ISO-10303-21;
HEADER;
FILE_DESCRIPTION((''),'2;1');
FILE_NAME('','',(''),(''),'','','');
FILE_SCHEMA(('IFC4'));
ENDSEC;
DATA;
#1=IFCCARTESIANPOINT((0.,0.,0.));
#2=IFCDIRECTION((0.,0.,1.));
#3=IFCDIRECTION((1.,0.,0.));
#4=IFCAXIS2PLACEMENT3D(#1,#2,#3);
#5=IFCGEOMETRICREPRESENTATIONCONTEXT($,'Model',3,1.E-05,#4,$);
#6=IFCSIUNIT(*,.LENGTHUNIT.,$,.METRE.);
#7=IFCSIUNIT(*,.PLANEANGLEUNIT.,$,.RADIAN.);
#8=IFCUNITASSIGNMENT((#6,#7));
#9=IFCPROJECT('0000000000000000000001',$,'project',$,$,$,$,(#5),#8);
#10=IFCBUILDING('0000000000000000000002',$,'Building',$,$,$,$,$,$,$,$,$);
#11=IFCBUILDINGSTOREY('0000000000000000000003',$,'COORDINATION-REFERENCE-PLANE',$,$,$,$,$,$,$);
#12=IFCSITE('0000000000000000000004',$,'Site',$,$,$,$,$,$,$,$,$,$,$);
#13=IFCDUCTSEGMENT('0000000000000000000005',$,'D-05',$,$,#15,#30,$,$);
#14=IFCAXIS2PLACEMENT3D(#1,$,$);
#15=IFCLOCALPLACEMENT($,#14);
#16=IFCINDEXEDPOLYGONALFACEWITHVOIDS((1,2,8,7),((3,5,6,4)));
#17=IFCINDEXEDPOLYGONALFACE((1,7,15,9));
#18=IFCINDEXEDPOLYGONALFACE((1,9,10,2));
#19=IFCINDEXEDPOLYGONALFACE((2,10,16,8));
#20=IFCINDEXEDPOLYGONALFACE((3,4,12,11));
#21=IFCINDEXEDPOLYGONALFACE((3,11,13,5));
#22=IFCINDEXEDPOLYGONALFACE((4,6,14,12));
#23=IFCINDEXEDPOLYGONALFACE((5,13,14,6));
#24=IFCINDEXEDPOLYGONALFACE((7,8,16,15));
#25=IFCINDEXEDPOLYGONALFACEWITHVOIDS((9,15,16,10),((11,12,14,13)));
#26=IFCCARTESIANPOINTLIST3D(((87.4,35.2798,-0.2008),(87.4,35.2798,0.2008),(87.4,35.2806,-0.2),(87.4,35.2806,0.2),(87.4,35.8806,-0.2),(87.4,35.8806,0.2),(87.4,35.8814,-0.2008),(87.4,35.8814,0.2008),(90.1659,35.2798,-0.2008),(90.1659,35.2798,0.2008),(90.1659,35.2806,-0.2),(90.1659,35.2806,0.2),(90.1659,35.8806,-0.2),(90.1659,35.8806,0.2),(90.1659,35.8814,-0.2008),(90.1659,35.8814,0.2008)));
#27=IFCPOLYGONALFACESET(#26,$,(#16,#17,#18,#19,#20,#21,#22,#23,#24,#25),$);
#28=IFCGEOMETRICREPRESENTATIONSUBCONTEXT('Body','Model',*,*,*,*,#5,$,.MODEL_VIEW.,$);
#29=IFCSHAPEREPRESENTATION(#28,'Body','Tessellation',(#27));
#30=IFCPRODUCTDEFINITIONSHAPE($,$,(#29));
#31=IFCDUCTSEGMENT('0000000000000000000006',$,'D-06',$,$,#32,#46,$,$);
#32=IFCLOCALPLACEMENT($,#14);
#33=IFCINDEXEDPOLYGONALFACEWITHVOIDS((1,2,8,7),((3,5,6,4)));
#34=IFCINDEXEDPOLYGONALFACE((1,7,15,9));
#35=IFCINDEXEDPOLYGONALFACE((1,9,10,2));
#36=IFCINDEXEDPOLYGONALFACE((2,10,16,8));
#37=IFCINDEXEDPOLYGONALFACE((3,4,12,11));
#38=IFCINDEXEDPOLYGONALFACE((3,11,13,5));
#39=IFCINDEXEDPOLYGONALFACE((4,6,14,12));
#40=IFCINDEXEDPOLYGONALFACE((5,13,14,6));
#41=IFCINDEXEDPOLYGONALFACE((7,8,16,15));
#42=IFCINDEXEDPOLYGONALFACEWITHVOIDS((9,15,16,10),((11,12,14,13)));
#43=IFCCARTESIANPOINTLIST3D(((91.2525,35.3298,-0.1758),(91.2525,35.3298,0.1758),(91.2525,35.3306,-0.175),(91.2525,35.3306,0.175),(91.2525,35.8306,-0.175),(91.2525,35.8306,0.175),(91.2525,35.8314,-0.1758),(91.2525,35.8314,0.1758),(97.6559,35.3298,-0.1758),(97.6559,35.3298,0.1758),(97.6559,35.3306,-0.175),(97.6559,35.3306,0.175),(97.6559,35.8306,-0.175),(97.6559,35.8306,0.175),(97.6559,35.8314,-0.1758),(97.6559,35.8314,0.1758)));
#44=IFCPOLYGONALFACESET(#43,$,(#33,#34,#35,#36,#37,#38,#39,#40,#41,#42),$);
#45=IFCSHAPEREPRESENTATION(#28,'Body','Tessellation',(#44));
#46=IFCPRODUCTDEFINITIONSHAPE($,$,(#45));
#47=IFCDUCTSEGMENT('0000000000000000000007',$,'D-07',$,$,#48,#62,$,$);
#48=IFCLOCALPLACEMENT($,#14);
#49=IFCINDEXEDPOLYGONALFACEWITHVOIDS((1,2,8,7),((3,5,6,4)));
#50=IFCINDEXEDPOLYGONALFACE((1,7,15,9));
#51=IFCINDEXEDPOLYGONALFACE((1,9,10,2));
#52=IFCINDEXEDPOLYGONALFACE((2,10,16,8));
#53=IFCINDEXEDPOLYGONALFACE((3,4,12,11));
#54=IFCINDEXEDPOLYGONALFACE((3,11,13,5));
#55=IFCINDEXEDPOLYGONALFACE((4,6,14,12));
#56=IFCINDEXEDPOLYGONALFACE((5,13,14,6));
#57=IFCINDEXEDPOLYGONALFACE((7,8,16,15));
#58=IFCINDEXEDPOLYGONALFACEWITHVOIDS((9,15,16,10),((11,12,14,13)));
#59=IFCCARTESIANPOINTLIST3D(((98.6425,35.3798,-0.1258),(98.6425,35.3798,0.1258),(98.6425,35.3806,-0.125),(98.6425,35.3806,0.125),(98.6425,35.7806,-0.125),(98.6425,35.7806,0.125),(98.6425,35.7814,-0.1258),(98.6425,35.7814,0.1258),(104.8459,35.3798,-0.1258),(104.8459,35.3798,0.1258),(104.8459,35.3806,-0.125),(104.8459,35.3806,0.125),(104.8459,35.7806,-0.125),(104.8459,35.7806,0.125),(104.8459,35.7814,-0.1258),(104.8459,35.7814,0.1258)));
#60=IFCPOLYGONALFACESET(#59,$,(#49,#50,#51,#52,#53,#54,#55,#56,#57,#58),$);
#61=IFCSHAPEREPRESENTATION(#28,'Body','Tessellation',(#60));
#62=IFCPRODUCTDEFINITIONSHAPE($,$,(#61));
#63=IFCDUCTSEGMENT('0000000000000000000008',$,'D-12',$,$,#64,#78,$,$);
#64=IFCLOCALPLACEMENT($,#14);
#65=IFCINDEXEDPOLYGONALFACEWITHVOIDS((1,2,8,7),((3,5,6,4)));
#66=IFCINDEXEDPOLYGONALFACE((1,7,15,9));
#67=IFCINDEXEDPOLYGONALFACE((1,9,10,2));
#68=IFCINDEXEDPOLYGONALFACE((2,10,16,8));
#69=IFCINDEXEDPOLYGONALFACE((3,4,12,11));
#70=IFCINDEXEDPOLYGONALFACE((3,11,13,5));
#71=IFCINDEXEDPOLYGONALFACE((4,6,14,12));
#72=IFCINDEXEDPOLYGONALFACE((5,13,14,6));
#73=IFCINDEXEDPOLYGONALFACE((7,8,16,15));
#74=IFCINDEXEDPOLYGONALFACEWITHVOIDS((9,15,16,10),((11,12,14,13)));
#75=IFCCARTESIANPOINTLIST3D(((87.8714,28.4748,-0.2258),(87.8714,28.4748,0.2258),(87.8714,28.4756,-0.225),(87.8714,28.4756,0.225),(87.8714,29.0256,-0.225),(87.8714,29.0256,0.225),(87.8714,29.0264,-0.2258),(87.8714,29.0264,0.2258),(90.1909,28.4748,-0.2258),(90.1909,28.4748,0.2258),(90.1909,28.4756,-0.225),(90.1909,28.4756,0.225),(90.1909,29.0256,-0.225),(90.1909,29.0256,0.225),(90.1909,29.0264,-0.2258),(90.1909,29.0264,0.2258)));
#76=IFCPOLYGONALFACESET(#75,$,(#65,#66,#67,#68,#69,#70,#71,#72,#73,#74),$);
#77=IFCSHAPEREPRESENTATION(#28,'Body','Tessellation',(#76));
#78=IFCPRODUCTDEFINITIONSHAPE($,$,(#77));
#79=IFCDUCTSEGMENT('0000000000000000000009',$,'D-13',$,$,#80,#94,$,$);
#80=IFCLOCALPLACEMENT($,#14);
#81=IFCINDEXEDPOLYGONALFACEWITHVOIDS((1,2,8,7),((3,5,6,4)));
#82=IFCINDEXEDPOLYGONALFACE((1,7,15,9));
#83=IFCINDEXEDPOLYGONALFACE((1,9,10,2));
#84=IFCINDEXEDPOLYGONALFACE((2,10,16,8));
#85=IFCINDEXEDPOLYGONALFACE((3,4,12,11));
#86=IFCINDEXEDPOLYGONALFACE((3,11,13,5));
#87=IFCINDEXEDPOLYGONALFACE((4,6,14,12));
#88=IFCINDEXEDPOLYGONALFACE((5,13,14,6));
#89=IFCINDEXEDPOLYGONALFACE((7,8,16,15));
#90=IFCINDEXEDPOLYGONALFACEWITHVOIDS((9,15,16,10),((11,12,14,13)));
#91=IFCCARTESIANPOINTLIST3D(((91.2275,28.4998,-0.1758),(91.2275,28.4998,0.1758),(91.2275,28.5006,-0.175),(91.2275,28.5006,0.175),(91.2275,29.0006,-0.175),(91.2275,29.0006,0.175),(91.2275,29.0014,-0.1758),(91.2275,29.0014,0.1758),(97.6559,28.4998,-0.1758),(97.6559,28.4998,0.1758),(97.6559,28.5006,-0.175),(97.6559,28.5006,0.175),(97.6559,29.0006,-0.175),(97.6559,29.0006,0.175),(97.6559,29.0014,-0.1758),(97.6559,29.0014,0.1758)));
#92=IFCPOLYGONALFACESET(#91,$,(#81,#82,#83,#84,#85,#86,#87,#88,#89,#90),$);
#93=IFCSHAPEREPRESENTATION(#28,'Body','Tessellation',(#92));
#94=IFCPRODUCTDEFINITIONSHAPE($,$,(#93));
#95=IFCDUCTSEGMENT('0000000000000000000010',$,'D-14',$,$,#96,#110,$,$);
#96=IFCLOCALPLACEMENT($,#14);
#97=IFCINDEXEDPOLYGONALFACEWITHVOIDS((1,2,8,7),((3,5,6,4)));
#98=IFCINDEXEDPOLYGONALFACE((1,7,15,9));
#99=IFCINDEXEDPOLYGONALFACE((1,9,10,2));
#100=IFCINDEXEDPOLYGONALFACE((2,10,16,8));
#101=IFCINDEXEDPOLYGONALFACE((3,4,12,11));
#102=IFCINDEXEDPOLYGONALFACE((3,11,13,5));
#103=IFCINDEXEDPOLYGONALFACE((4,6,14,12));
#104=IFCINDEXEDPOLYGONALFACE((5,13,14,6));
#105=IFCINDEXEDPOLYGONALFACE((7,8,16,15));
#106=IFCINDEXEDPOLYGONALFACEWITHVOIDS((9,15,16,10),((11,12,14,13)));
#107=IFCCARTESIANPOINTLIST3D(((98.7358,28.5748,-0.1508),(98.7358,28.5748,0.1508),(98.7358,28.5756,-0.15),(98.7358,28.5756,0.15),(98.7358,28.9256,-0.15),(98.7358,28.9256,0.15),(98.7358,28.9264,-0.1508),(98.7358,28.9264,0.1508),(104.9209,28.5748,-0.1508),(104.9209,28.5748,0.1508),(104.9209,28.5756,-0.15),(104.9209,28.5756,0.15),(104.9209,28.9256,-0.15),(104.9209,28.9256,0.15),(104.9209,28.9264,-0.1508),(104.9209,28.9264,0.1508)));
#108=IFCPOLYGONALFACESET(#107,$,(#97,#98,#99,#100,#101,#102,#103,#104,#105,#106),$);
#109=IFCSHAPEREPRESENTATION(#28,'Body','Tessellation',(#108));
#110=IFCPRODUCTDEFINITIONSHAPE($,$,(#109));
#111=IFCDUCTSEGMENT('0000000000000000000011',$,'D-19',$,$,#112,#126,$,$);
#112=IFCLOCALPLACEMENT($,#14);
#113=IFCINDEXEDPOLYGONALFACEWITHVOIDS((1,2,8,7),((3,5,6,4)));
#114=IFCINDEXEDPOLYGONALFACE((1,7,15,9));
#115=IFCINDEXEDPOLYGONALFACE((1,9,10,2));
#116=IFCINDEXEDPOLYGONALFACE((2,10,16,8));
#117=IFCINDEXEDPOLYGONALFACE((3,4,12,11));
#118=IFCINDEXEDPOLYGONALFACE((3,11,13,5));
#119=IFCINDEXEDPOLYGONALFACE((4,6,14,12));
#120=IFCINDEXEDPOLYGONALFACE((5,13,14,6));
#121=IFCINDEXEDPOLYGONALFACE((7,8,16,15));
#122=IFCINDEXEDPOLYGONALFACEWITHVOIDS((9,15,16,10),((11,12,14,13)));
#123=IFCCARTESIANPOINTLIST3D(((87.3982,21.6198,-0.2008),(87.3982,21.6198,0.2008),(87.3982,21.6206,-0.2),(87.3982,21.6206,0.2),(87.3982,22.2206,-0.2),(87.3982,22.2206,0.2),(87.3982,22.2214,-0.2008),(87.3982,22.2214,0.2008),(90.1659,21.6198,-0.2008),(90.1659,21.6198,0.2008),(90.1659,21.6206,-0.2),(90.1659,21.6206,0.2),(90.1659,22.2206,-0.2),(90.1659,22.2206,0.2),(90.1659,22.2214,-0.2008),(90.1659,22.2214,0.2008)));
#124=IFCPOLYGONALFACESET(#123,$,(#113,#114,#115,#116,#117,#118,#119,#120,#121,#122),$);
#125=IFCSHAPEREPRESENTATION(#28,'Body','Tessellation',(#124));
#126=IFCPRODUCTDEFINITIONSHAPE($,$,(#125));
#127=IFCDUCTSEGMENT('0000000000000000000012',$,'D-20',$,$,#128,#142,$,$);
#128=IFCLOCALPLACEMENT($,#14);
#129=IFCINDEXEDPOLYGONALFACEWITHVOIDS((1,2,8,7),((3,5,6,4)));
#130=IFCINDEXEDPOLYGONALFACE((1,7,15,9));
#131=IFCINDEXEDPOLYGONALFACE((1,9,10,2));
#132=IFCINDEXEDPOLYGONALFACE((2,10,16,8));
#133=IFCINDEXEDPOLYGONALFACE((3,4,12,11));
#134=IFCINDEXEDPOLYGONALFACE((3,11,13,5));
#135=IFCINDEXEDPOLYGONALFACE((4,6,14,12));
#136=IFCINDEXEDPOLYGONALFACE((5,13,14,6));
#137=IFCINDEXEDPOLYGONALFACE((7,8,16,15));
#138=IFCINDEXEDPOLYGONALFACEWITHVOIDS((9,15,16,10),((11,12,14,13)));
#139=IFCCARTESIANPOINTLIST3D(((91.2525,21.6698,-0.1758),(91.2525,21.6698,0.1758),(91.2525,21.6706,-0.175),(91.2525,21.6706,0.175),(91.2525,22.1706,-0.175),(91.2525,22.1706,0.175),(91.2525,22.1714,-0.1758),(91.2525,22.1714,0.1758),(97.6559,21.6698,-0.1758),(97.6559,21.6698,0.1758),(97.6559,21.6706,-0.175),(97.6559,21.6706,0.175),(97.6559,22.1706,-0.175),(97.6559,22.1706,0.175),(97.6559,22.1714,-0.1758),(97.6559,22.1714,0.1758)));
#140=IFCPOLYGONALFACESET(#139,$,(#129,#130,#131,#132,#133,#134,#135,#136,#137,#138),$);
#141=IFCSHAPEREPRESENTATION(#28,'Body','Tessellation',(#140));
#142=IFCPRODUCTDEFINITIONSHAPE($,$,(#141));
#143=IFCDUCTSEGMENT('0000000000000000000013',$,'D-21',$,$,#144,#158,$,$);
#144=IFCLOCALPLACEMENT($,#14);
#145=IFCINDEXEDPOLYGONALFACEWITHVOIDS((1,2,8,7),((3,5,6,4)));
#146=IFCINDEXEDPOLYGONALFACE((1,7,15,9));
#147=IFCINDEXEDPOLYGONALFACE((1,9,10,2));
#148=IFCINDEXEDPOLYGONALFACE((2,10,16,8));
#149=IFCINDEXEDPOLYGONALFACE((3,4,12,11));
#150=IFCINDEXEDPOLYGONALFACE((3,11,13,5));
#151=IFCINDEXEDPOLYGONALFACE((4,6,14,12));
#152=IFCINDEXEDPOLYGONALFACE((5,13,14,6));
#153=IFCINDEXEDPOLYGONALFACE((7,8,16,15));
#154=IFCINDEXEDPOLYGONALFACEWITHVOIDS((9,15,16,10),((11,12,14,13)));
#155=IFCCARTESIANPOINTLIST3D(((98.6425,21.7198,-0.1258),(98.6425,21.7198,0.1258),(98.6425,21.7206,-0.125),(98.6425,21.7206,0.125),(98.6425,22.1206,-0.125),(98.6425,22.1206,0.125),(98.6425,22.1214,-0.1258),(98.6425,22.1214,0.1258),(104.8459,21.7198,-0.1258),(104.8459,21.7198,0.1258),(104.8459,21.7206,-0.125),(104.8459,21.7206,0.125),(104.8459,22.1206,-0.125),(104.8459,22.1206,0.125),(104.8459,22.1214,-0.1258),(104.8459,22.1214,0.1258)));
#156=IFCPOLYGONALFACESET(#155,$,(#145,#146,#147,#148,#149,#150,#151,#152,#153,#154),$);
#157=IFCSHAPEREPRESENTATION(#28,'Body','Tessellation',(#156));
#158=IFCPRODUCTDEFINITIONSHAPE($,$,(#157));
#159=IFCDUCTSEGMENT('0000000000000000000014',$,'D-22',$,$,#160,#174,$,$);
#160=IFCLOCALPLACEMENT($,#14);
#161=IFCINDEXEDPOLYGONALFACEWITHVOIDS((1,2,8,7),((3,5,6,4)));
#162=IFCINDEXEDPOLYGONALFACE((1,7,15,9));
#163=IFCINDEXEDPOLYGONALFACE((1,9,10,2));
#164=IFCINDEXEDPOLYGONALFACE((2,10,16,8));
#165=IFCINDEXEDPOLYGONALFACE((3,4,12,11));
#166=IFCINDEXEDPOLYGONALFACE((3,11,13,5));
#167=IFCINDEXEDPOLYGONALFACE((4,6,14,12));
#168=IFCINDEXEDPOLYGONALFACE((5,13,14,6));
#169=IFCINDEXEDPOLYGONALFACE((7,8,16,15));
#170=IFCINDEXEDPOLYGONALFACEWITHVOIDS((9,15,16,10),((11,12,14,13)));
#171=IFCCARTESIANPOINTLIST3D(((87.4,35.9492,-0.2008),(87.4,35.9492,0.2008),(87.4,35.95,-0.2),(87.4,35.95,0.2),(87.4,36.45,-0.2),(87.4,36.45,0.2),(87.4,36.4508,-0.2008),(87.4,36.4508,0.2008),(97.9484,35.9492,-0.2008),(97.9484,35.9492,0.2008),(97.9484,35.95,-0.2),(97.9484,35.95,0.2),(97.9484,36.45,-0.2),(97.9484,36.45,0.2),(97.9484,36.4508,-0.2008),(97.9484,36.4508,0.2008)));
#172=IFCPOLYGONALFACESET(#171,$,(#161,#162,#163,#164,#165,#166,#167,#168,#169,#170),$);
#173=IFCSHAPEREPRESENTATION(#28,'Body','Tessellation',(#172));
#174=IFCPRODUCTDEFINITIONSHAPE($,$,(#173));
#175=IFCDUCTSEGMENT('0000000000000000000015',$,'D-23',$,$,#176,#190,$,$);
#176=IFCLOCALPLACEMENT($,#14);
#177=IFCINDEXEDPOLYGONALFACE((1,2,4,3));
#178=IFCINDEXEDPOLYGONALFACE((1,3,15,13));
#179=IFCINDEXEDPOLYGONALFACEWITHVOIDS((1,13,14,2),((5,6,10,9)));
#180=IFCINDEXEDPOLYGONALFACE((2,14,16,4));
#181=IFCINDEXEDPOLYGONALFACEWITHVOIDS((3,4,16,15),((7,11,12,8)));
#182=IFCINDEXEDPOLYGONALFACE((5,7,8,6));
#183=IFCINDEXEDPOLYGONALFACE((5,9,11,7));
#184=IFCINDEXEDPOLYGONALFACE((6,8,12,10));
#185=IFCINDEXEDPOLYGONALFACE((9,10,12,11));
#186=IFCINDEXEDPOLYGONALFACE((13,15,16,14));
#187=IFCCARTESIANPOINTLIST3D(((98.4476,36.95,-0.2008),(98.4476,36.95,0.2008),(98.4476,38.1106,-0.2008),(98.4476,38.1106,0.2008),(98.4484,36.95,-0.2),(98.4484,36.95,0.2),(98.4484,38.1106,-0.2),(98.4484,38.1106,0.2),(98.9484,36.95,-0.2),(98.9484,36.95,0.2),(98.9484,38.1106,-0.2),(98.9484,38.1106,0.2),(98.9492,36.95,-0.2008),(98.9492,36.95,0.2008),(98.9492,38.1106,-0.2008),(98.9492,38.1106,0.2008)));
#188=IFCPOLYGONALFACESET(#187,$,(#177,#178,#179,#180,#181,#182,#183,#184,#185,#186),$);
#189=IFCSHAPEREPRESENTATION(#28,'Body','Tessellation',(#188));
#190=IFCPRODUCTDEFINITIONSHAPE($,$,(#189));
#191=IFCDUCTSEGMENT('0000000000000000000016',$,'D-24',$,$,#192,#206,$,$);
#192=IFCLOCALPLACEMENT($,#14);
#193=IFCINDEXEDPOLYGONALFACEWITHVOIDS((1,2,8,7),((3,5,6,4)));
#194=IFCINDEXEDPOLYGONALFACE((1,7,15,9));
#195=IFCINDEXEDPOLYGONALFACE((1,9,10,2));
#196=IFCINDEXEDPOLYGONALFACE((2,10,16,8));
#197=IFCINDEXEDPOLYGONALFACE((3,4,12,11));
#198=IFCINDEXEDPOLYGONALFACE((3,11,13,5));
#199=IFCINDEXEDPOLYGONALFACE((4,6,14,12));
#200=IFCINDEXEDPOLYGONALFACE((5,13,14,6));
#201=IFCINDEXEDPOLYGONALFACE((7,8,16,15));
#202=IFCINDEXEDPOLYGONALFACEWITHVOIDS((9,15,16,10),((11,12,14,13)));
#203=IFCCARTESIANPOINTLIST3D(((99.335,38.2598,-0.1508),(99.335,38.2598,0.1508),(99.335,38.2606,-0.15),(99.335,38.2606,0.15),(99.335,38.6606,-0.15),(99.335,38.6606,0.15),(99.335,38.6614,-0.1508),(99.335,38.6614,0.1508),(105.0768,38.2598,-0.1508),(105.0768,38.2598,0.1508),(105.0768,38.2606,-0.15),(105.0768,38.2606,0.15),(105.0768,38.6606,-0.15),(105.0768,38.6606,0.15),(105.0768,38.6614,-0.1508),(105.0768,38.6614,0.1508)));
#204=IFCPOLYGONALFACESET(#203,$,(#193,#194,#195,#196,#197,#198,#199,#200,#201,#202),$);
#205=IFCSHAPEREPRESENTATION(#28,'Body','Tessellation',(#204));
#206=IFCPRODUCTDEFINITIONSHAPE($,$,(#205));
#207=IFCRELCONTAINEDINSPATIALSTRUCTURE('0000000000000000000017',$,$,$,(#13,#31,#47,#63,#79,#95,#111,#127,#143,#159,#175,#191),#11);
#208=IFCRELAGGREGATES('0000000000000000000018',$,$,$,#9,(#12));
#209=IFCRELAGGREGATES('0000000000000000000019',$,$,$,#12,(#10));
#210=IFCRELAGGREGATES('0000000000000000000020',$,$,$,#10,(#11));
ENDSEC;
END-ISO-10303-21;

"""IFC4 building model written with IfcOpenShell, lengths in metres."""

from ifc_helpers import new_model, si_unit, frame, origin, origin_with_axes, place, context, subcontext, project, spatial, hollow_rectangle, extrude, element, save


model = new_model("IFC4")

# Units and contexts
model_context = context("Model", 3, precision=1e-05, world=origin_with_axes())
body_context = subcontext(model_context, "Body", "Model", "MODEL_VIEW")
ifc_project = project(units=[si_unit("LENGTHUNIT", "METRE"), si_unit("PLANEANGLEUNIT", "RADIAN")], contexts=[model_context])

# Site, building, storey
site = spatial("IfcSite", under=ifc_project, Name="Site")
building = spatial("IfcBuilding", under=site, Name="Building")
storey = spatial("IfcBuildingStorey", under=building, Name="COORDINATION-REFERENCE-PLANE")

# Duct segments
duct_segment_1_placement = place(None, frame((87.4, 35.5806, 0.0), z_axis=(1.0, 0.0, 0.0), x_axis=(0.0, 1.0, 0.0)))
element("IfcDuctSegment", 1, at=duct_segment_1_placement, inside=storey, Name="D-05", context=body_context, shape_type="SweptSolid", body=[
    extrude(hollow_rectangle(XDim=0.6016, YDim=0.4016, WallThickness=0.0008), origin(), (0.0, 0.0, 1.0), 2.7659),
])
duct_segment_2_placement = place(None, frame((91.2525, 35.5806, 0.0), z_axis=(1.0, 0.0, 0.0), x_axis=(0.0, 1.0, 0.0)))
element("IfcDuctSegment", 2, at=duct_segment_2_placement, inside=storey, Name="D-06", context=body_context, shape_type="SweptSolid", body=[
    extrude(hollow_rectangle(XDim=0.5016, YDim=0.3516, WallThickness=0.0008), origin(), (0.0, 0.0, 1.0), 6.4034),
])
duct_segment_3_placement = place(None, frame((98.6425, 35.5806, 0.0), z_axis=(1.0, 0.0, 0.0), x_axis=(0.0, 1.0, 0.0)))
element("IfcDuctSegment", 3, at=duct_segment_3_placement, inside=storey, Name="D-07", context=body_context, shape_type="SweptSolid", body=[
    extrude(hollow_rectangle(XDim=0.4016, YDim=0.2516, WallThickness=0.0008), origin(), (0.0, 0.0, 1.0), 6.2034),
])
duct_segment_4_placement = place(None, frame((87.8714, 28.7506, 0.0), z_axis=(1.0, 0.0, 0.0), x_axis=(0.0, 1.0, 0.0)))
element("IfcDuctSegment", 4, at=duct_segment_4_placement, inside=storey, Name="D-12", context=body_context, shape_type="SweptSolid", body=[
    extrude(hollow_rectangle(XDim=0.5516, YDim=0.4516, WallThickness=0.0008), origin(), (0.0, 0.0, 1.0), 2.3195),
])
duct_segment_5_placement = place(None, frame((91.2275, 28.7506, 0.0), z_axis=(1.0, 0.0, 0.0), x_axis=(0.0, 1.0, 0.0)))
element("IfcDuctSegment", 5, at=duct_segment_5_placement, inside=storey, Name="D-13", context=body_context, shape_type="SweptSolid", body=[
    extrude(hollow_rectangle(XDim=0.5016, YDim=0.3516, WallThickness=0.0008), origin(), (0.0, 0.0, 1.0), 6.4284),
])
duct_segment_6_placement = place(None, frame((98.7358, 28.7506, 0.0), z_axis=(1.0, 0.0, 0.0), x_axis=(0.0, 1.0, 0.0)))
element("IfcDuctSegment", 6, at=duct_segment_6_placement, inside=storey, Name="D-14", context=body_context, shape_type="SweptSolid", body=[
    extrude(hollow_rectangle(XDim=0.3516, YDim=0.3016, WallThickness=0.0008), origin(), (0.0, 0.0, 1.0), 6.1851),
])
duct_segment_7_placement = place(None, frame((87.3982, 21.9206, 0.0), z_axis=(1.0, 0.0, 0.0), x_axis=(0.0, 1.0, 0.0)))
element("IfcDuctSegment", 7, at=duct_segment_7_placement, inside=storey, Name="D-19", context=body_context, shape_type="SweptSolid", body=[
    extrude(hollow_rectangle(XDim=0.6016, YDim=0.4016, WallThickness=0.0008), origin(), (0.0, 0.0, 1.0), 2.7677),
])
duct_segment_8_placement = place(None, frame((91.2525, 21.9206, 0.0), z_axis=(1.0, 0.0, 0.0), x_axis=(0.0, 1.0, 0.0)))
element("IfcDuctSegment", 8, at=duct_segment_8_placement, inside=storey, Name="D-20", context=body_context, shape_type="SweptSolid", body=[
    extrude(hollow_rectangle(XDim=0.5016, YDim=0.3516, WallThickness=0.0008), origin(), (0.0, 0.0, 1.0), 6.4034),
])
duct_segment_9_placement = place(None, frame((98.6425, 21.9206, 0.0), z_axis=(1.0, 0.0, 0.0), x_axis=(0.0, 1.0, 0.0)))
element("IfcDuctSegment", 9, at=duct_segment_9_placement, inside=storey, Name="D-21", context=body_context, shape_type="SweptSolid", body=[
    extrude(hollow_rectangle(XDim=0.4016, YDim=0.2516, WallThickness=0.0008), origin(), (0.0, 0.0, 1.0), 6.2034),
])
duct_segment_10_placement = place(None, frame((87.4, 36.2, 0.0), z_axis=(1.0, 0.0, 0.0), x_axis=(0.0, 1.0, 0.0)))
element("IfcDuctSegment", 10, at=duct_segment_10_placement, inside=storey, Name="D-22", context=body_context, shape_type="SweptSolid", body=[
    extrude(hollow_rectangle(XDim=0.5016, YDim=0.4016, WallThickness=0.0008), origin(), (0.0, 0.0, 1.0), 10.5484),
])
duct_segment_11_placement = place(None, frame((98.6984, 36.95, 0.0), z_axis=(0.0, 1.0, 0.0), x_axis=(1.0, 0.0, 0.0)))
element("IfcDuctSegment", 11, at=duct_segment_11_placement, inside=storey, Name="D-23", context=body_context, shape_type="SweptSolid", body=[
    extrude(hollow_rectangle(XDim=0.5016, YDim=0.4016, WallThickness=0.0008), origin(), (0.0, 0.0, 1.0), 1.1606),
])
duct_segment_12_placement = place(None, frame((99.335, 38.4606, 0.0), z_axis=(1.0, 0.0, 0.0), x_axis=(0.0, 1.0, 0.0)))
element("IfcDuctSegment", 12, at=duct_segment_12_placement, inside=storey, Name="D-24", context=body_context, shape_type="SweptSolid", body=[
    extrude(hollow_rectangle(XDim=0.4016, YDim=0.3016, WallThickness=0.0008), origin(), (0.0, 0.0, 1.0), 5.7417),
])

save(model, "model.ifc")
